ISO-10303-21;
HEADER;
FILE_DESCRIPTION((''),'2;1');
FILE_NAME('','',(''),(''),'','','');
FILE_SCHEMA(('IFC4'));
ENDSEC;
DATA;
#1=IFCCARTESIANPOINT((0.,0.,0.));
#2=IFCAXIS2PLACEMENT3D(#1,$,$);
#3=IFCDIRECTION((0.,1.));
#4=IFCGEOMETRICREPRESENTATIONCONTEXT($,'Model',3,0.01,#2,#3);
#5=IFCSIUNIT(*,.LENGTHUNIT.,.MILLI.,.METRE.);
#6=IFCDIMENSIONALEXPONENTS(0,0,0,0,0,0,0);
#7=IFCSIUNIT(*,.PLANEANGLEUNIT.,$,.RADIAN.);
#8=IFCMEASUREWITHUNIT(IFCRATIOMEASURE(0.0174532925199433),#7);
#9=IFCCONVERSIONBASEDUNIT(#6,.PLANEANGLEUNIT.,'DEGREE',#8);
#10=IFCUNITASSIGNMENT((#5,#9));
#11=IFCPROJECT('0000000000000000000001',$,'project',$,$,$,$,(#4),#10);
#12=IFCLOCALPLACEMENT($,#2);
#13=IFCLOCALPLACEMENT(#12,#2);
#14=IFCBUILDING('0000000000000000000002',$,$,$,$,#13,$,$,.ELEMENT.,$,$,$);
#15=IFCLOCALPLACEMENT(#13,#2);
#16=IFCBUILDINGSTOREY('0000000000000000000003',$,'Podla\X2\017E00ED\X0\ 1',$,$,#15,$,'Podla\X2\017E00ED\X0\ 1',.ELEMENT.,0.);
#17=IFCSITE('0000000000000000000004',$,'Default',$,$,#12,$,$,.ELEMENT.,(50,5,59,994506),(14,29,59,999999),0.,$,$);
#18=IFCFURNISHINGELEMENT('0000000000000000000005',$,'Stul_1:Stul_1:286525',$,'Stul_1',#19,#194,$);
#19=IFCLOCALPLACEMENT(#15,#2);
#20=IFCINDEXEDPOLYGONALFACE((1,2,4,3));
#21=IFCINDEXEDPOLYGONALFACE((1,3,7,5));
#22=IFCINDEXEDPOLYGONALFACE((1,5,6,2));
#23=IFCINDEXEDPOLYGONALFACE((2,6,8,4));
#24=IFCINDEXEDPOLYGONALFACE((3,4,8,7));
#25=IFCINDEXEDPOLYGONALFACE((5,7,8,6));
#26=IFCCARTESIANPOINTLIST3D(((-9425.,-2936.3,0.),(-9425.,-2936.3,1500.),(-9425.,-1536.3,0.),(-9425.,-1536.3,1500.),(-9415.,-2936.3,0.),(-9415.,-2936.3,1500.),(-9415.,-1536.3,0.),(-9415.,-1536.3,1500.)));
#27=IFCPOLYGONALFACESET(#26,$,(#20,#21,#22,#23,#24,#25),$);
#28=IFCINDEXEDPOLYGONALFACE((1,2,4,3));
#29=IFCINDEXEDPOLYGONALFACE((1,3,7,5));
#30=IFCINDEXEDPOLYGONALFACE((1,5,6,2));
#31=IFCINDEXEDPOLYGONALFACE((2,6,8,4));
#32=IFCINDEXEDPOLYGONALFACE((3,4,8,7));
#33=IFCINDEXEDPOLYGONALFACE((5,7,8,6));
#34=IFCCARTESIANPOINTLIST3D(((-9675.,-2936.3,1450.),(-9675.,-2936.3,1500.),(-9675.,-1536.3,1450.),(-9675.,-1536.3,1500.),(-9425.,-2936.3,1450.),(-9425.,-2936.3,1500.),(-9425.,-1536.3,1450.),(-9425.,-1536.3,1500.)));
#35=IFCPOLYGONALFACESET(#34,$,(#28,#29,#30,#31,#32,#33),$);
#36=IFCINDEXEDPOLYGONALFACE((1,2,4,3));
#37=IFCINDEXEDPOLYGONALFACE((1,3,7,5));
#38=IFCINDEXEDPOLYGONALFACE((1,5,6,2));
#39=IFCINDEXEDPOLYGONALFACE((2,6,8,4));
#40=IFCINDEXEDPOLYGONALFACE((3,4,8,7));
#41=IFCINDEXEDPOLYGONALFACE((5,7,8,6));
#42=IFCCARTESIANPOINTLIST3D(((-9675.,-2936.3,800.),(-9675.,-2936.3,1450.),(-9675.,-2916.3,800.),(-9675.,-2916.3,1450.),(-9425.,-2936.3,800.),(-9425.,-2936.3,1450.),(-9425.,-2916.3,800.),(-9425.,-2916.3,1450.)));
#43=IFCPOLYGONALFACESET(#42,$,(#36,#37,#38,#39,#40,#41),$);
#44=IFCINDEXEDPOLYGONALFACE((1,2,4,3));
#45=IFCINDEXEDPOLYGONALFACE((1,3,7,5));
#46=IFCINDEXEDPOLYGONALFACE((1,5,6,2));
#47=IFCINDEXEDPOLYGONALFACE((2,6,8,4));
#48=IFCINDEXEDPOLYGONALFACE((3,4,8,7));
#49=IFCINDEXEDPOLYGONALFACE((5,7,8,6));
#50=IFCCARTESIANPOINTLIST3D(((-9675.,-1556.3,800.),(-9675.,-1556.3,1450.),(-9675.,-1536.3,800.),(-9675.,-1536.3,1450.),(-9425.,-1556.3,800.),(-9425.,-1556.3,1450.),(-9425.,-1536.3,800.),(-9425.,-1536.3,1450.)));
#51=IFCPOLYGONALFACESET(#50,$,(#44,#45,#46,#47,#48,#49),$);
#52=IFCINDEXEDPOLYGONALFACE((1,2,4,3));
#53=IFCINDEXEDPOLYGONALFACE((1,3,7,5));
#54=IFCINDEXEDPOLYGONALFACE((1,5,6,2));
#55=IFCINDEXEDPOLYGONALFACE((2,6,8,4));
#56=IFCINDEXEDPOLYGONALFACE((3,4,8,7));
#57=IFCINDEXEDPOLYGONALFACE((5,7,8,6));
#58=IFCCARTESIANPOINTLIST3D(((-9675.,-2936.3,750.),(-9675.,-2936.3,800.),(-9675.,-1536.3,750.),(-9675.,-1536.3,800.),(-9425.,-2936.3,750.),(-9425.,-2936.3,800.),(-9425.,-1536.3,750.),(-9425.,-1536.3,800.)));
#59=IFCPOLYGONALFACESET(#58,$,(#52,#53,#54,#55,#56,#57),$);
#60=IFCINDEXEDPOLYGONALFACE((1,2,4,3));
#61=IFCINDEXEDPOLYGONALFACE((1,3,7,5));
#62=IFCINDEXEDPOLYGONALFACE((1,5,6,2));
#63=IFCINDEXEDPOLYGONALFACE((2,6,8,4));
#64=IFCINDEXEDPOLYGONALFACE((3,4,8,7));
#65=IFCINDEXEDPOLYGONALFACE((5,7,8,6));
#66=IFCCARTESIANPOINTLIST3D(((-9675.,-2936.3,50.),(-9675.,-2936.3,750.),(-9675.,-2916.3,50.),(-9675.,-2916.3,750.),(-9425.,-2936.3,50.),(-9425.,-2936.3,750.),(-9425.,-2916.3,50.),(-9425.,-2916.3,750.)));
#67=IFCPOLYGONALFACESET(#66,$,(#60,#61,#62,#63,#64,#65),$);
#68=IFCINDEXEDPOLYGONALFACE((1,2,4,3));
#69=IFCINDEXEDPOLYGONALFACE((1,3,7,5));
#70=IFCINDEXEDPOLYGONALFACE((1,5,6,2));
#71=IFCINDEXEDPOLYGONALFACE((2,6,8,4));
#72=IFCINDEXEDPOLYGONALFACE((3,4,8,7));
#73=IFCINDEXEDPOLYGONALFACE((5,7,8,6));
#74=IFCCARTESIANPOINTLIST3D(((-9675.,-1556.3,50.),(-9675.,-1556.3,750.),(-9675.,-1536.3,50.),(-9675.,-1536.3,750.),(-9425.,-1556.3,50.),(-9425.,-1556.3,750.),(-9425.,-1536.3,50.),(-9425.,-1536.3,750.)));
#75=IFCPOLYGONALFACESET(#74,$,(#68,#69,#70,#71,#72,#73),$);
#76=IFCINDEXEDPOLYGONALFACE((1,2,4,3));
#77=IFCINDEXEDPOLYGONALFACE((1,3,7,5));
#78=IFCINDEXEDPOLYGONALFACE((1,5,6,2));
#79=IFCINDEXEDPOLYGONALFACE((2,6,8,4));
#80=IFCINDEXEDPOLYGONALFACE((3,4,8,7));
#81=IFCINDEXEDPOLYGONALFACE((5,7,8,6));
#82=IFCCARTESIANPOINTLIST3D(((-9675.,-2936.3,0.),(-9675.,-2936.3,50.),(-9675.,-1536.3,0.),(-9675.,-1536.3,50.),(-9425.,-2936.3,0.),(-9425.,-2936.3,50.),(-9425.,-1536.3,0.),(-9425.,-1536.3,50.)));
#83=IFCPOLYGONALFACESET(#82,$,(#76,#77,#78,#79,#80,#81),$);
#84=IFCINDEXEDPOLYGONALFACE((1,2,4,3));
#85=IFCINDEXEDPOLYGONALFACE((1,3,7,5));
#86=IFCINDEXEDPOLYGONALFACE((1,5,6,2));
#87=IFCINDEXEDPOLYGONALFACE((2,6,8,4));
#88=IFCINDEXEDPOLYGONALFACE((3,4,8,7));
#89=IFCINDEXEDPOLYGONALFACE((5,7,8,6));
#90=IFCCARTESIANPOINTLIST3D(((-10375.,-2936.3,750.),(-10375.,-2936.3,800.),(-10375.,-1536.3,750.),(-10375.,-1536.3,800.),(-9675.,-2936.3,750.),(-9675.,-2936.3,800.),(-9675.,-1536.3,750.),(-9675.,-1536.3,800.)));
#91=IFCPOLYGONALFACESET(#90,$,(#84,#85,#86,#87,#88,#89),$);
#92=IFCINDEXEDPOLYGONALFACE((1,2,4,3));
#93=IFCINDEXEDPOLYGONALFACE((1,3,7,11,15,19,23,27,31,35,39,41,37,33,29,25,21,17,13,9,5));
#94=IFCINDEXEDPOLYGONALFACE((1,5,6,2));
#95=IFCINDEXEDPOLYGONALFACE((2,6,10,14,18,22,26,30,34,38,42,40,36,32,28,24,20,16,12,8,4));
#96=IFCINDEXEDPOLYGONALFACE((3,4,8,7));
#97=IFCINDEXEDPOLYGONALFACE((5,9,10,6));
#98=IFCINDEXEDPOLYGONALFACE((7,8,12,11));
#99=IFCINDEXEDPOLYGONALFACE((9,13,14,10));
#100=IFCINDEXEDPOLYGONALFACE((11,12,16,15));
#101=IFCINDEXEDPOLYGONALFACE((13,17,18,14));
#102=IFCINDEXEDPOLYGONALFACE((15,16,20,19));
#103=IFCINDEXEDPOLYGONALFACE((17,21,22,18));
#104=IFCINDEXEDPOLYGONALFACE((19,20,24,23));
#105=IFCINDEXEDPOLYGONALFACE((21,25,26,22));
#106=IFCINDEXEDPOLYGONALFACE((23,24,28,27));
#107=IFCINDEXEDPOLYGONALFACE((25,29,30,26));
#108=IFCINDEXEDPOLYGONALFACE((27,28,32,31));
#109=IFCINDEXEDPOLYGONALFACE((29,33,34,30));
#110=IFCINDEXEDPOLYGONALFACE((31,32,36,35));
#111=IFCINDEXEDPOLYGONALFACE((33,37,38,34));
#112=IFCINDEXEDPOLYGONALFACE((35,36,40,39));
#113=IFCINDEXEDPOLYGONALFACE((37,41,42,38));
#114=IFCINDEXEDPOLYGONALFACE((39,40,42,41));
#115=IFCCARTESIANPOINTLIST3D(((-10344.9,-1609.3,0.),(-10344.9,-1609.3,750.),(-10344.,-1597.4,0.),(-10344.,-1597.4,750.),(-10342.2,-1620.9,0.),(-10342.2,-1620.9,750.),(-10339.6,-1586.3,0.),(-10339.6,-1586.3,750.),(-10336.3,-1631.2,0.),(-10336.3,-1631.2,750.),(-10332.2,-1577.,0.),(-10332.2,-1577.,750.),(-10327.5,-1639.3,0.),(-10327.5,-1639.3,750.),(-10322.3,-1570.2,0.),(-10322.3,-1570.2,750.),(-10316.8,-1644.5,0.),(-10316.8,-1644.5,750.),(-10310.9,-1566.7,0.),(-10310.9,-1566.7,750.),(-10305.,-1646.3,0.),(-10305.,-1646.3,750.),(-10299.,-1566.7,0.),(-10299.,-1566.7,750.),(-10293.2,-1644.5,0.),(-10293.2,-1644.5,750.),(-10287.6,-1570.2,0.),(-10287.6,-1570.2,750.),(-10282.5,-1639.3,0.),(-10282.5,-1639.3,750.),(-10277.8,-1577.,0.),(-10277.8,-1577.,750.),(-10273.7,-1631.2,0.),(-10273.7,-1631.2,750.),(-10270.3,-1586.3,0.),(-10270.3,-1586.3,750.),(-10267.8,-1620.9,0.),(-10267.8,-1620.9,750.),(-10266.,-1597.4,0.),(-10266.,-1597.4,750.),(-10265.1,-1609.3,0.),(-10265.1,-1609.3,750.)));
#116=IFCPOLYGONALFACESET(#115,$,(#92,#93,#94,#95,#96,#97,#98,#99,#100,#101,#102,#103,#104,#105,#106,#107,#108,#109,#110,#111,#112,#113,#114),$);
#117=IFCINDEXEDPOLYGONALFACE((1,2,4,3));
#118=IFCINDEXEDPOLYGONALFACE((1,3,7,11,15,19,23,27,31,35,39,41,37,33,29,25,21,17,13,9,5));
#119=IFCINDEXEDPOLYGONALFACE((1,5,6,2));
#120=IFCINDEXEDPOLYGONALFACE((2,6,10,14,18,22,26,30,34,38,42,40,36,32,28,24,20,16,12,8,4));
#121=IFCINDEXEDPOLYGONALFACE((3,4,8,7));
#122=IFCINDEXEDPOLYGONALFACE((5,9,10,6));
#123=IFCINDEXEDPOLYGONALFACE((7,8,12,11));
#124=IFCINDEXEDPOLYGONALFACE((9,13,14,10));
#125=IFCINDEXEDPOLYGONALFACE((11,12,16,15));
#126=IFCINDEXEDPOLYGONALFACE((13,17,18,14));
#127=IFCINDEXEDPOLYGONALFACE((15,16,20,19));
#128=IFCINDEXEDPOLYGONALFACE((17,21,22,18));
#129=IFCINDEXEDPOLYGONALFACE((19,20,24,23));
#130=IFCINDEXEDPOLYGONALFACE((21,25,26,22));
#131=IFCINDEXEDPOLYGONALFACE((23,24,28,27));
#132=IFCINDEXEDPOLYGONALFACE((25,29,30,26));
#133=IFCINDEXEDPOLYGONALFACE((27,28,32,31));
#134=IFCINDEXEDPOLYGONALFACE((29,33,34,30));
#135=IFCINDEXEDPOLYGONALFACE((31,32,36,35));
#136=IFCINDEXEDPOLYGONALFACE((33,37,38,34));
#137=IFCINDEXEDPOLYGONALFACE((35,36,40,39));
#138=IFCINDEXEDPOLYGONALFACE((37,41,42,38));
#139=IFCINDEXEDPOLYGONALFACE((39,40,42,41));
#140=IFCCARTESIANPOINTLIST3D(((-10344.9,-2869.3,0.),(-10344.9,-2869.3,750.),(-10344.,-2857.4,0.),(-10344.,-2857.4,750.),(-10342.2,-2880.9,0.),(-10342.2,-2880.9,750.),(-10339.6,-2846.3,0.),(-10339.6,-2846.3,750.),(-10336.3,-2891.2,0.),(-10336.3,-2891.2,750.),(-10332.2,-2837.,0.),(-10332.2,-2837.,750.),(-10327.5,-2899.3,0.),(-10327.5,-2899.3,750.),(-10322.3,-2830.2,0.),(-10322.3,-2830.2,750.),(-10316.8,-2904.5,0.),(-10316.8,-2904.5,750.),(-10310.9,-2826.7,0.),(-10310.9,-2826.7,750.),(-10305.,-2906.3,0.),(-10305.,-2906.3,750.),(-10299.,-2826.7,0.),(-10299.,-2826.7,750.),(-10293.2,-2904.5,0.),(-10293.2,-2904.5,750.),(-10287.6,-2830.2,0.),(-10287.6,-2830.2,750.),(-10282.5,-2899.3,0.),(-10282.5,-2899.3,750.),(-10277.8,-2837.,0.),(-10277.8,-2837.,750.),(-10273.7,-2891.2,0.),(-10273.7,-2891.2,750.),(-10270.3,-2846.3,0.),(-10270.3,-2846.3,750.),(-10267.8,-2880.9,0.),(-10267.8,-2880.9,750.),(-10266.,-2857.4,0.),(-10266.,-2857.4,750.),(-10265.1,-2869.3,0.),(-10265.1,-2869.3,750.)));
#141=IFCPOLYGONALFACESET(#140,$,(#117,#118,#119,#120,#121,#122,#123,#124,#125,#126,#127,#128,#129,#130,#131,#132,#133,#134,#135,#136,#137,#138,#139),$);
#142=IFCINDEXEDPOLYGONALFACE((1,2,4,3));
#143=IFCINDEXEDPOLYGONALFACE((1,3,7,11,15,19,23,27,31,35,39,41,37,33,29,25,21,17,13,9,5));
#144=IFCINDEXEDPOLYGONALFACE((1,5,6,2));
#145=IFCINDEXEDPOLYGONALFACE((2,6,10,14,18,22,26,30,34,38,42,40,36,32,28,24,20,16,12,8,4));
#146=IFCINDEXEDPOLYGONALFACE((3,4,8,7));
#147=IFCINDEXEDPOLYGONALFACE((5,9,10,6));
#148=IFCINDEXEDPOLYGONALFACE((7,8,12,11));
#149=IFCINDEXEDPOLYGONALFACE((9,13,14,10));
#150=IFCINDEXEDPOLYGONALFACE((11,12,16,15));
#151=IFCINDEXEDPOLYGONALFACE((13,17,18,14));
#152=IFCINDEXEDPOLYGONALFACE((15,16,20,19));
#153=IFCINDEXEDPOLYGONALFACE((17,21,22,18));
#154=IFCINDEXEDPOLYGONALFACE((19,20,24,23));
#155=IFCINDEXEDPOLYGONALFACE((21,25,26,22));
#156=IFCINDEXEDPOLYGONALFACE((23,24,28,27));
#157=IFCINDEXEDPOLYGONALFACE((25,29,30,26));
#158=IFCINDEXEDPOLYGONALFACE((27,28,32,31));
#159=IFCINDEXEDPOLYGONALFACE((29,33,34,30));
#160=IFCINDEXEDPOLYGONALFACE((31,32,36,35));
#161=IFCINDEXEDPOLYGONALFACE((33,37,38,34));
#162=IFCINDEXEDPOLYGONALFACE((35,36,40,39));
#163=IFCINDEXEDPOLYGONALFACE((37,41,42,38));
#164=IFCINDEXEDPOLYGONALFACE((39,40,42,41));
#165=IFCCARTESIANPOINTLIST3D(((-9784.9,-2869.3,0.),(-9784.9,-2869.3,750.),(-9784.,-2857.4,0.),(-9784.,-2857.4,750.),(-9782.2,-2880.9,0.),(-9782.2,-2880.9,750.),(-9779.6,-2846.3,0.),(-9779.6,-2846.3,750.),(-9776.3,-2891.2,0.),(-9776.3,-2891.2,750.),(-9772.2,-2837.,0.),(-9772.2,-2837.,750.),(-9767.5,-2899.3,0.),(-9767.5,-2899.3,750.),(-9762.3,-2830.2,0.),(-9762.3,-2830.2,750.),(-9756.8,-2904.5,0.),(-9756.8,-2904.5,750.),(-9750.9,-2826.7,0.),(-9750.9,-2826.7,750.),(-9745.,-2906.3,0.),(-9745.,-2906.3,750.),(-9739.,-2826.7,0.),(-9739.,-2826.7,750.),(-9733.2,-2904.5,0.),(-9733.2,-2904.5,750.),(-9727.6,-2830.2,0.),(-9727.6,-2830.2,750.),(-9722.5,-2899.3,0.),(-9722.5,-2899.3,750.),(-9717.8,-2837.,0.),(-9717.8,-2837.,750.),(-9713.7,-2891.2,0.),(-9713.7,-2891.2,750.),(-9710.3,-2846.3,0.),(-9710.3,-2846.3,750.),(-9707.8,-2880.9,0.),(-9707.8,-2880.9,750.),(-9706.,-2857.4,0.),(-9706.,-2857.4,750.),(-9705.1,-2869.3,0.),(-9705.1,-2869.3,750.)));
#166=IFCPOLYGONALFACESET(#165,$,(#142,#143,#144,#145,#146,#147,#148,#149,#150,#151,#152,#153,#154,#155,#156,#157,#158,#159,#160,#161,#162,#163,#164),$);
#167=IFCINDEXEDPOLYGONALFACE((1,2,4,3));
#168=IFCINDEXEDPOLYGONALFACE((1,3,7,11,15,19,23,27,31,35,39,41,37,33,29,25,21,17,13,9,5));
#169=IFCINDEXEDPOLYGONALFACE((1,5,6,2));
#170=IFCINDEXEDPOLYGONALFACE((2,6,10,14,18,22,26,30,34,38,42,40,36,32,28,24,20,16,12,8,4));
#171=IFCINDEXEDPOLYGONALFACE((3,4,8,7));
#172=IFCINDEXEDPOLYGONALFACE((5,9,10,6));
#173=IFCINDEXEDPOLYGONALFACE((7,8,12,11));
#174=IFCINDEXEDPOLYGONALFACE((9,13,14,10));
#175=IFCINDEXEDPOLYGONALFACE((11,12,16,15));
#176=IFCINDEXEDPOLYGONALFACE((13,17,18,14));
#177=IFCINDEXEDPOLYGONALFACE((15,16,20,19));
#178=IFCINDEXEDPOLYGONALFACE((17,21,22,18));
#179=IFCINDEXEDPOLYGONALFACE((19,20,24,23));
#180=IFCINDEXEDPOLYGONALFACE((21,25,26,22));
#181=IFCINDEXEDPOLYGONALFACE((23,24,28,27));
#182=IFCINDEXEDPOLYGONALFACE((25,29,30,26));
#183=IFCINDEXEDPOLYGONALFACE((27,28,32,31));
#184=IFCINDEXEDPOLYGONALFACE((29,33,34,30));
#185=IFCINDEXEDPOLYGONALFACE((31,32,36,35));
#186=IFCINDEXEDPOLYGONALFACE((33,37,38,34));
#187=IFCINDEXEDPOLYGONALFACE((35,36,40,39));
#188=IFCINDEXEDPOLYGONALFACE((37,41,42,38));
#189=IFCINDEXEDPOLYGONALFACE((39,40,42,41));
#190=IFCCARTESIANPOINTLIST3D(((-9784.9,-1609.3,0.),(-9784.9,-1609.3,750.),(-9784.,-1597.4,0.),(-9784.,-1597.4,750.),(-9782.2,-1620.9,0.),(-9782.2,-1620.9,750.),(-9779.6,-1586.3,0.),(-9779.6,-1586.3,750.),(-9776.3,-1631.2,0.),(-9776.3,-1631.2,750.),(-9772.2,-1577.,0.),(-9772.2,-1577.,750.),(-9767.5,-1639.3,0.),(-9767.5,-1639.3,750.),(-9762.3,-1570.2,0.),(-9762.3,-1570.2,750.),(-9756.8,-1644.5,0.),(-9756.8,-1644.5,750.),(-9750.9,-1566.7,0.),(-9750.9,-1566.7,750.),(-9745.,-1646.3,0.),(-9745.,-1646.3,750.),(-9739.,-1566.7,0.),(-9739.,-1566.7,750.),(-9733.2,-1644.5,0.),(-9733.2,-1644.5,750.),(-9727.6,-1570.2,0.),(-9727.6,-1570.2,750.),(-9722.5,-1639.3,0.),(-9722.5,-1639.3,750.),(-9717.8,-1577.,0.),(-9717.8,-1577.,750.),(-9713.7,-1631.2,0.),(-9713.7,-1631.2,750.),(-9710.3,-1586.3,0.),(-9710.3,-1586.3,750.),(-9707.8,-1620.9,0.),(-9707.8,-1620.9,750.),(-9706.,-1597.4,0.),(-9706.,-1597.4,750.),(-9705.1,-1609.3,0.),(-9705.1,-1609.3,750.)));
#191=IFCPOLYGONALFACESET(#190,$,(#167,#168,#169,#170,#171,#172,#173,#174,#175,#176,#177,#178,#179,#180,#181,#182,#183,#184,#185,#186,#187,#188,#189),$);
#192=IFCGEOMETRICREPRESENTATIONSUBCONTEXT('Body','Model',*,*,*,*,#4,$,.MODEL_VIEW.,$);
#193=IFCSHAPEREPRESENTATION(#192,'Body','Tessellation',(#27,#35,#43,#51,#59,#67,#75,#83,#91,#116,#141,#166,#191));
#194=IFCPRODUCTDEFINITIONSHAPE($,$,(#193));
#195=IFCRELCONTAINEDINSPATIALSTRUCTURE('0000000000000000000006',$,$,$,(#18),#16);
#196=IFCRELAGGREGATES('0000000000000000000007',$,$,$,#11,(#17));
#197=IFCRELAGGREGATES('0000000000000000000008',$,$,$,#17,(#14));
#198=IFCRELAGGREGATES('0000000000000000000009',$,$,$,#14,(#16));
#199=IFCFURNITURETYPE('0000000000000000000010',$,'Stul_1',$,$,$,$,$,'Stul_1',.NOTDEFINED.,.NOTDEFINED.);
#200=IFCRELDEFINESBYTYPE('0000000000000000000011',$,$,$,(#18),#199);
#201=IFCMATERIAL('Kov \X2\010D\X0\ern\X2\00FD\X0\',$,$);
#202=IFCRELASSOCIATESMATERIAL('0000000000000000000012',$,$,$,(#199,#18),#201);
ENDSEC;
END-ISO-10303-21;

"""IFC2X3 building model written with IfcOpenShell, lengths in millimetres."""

from ifc_helpers import new_model, entity, si_unit, converted_unit, direction, frame, frame_2d, origin, origin_2d_with_axis, place, context, subcontext, project, spatial, rectangle, circle, extrude, source, transform, mapped, material, type_object, type_shapes, element, save


model = new_model("IFC2X3")

# Units and contexts
model_context = context("Model", 3, precision=0.01, world=origin(), true_north=direction((0.0, 1.0)))
body_context = subcontext(model_context, "Body", "Model", "MODEL_VIEW")
ifc_project = project(units=[si_unit("LENGTHUNIT", "METRE", prefix="MILLI"), converted_unit("PLANEANGLEUNIT", "DEGREE", entity("IfcRatioMeasure", 0.0174532925199433), si_unit("PLANEANGLEUNIT", "RADIAN"), dimensions=[0, 0, 0, 0, 0, 0, 0])], contexts=[model_context])

# Site, building, storey
site_placement = place(None, origin())
site = spatial("IfcSite", under=ifc_project, at=site_placement, Name="Default", CompositionType="ELEMENT", RefLatitude=(50, 5, 59, 994506), RefLongitude=(14, 29, 59, 999999), RefElevation=0.0)
building_placement = place(site_placement, origin())
building = spatial("IfcBuilding", under=site, at=building_placement, CompositionType="ELEMENT")
storey_placement = place(building_placement, origin())
storey = spatial("IfcBuildingStorey", under=building, at=storey_placement, Name="Podlaží 1", LongName="Podlaží 1", CompositionType="ELEMENT", Elevation=0.0)

# Furnishing element
ifc_material_1 = material(Name="Kov černý")
furniture_type = type_object("IfcFurnitureType", Name="Stul_1", ElementType="Stul_1", material=ifc_material_1)
shared_shape_1 = source(origin(), body_context, "Body", "SweptSolid", [
    extrude(rectangle(XDim=1400.0, YDim=10.0, at=origin_2d_with_axis()), frame((0.0, 605.0, 0.0), z_axis=(0.0, 0.0, 1.0), x_axis=(-1.0, 0.0, 0.0)), (0.0, 0.0, 1.0), 1500.0),
    extrude(rectangle(XDim=1400.0, YDim=250.0, at=frame_2d((0.0, 0.0), x_axis=(1.0, 0.0))), frame((0.0, 475.0, 1450.0), z_axis=(0.0, 0.0, 1.0), x_axis=(-1.0, 0.0, 0.0)), (0.0, 0.0, 1.0), 50.0),
    extrude(rectangle(XDim=20.0, YDim=250.0, at=origin_2d_with_axis()), frame((690.0, 475.0, 800.0), z_axis=(0.0, 0.0, 1.0), x_axis=(-1.0, 0.0, 0.0)), (0.0, 0.0, 1.0), 650.0),
    extrude(rectangle(XDim=20.0, YDim=250.0, at=frame_2d((0.0, 0.0), x_axis=(1.0, 0.0))), frame((-690.0, 475.0, 800.0), z_axis=(0.0, 0.0, 1.0), x_axis=(-1.0, 0.0, 0.0)), (0.0, 0.0, 1.0), 650.0),
    extrude(rectangle(XDim=1400.0, YDim=250.0, at=origin_2d_with_axis()), frame((0.0, 475.0, 750.0), z_axis=(0.0, 0.0, 1.0), x_axis=(-1.0, 0.0, 0.0)), (0.0, 0.0, 1.0), 50.0),
    extrude(rectangle(XDim=20.0, YDim=250.0, at=origin_2d_with_axis()), frame((690.0, 475.0, 50.0), z_axis=(0.0, 0.0, 1.0), x_axis=(-1.0, 0.0, 0.0)), (0.0, 0.0, 1.0), 700.0),
    extrude(rectangle(XDim=20.0, YDim=250.0, at=frame_2d((0.0, 0.0), x_axis=(1.0, 0.0))), frame((-690.0, 475.0, 50.0), z_axis=(0.0, 0.0, 1.0), x_axis=(-1.0, 0.0, 0.0)), (0.0, 0.0, 1.0), 700.0),
    extrude(rectangle(XDim=1400.0, YDim=250.0, at=origin_2d_with_axis()), frame((0.0, 475.0, 0.0), z_axis=(0.0, 0.0, 1.0), x_axis=(-1.0, 0.0, 0.0)), (0.0, 0.0, 1.0), 50.0),
    extrude(rectangle(XDim=1400.0, YDim=700.0, at=origin_2d_with_axis()), frame((0.0, 0.0, 750.0), z_axis=(0.0, 0.0, 1.0), x_axis=(-1.0, 0.0, 0.0)), (0.0, 0.0, 1.0), 50.0),
    extrude(circle(Radius=40.0, at=frame_2d((0.0, 0.0), x_axis=(1.0, 0.0))), frame((-630.0, -280.0, 0.0)), (0.0, 0.0, 1.0), 750.0),
    extrude(circle(Radius=40.0, at=frame_2d((0.0, 0.0), x_axis=(1.0, 0.0))), frame((630.0, -280.0, 0.0)), (0.0, 0.0, 1.0), 750.0),
    extrude(circle(Radius=40.0, at=frame_2d((0.0, 0.0), x_axis=(1.0, 0.0))), frame((630.0, 280.0, 0.0)), (0.0, 0.0, 1.0), 750.0),
    extrude(circle(Radius=40.0, at=frame_2d((0.0, 0.0), x_axis=(1.0, 0.0))), frame((-630.0, 280.0, 0.0)), (0.0, 0.0, 1.0), 750.0),
])
type_shapes(furniture_type, [shared_shape_1])
for number, where, z_axis, x_axis, name in (
    (1, (-10025.0, -2236.3, 0.0), (0.0, 0.0, 1.0), (0.0, -1.0, 0.0), "Stul_1:Stul_1:286525"),
):
    element("IfcFurnishingElement", number, at=place(storey_placement, frame(where, z_axis=z_axis, x_axis=x_axis)), inside=storey, type_object=furniture_type, material=ifc_material_1, Name=name, ObjectType="Stul_1", context=body_context, shape_type="MappedRepresentation", body=[
        mapped(shared_shape_1, transform((0.0, 0.0, 0.0), scale=1.0)),
    ])

save(model, "model.ifc")
